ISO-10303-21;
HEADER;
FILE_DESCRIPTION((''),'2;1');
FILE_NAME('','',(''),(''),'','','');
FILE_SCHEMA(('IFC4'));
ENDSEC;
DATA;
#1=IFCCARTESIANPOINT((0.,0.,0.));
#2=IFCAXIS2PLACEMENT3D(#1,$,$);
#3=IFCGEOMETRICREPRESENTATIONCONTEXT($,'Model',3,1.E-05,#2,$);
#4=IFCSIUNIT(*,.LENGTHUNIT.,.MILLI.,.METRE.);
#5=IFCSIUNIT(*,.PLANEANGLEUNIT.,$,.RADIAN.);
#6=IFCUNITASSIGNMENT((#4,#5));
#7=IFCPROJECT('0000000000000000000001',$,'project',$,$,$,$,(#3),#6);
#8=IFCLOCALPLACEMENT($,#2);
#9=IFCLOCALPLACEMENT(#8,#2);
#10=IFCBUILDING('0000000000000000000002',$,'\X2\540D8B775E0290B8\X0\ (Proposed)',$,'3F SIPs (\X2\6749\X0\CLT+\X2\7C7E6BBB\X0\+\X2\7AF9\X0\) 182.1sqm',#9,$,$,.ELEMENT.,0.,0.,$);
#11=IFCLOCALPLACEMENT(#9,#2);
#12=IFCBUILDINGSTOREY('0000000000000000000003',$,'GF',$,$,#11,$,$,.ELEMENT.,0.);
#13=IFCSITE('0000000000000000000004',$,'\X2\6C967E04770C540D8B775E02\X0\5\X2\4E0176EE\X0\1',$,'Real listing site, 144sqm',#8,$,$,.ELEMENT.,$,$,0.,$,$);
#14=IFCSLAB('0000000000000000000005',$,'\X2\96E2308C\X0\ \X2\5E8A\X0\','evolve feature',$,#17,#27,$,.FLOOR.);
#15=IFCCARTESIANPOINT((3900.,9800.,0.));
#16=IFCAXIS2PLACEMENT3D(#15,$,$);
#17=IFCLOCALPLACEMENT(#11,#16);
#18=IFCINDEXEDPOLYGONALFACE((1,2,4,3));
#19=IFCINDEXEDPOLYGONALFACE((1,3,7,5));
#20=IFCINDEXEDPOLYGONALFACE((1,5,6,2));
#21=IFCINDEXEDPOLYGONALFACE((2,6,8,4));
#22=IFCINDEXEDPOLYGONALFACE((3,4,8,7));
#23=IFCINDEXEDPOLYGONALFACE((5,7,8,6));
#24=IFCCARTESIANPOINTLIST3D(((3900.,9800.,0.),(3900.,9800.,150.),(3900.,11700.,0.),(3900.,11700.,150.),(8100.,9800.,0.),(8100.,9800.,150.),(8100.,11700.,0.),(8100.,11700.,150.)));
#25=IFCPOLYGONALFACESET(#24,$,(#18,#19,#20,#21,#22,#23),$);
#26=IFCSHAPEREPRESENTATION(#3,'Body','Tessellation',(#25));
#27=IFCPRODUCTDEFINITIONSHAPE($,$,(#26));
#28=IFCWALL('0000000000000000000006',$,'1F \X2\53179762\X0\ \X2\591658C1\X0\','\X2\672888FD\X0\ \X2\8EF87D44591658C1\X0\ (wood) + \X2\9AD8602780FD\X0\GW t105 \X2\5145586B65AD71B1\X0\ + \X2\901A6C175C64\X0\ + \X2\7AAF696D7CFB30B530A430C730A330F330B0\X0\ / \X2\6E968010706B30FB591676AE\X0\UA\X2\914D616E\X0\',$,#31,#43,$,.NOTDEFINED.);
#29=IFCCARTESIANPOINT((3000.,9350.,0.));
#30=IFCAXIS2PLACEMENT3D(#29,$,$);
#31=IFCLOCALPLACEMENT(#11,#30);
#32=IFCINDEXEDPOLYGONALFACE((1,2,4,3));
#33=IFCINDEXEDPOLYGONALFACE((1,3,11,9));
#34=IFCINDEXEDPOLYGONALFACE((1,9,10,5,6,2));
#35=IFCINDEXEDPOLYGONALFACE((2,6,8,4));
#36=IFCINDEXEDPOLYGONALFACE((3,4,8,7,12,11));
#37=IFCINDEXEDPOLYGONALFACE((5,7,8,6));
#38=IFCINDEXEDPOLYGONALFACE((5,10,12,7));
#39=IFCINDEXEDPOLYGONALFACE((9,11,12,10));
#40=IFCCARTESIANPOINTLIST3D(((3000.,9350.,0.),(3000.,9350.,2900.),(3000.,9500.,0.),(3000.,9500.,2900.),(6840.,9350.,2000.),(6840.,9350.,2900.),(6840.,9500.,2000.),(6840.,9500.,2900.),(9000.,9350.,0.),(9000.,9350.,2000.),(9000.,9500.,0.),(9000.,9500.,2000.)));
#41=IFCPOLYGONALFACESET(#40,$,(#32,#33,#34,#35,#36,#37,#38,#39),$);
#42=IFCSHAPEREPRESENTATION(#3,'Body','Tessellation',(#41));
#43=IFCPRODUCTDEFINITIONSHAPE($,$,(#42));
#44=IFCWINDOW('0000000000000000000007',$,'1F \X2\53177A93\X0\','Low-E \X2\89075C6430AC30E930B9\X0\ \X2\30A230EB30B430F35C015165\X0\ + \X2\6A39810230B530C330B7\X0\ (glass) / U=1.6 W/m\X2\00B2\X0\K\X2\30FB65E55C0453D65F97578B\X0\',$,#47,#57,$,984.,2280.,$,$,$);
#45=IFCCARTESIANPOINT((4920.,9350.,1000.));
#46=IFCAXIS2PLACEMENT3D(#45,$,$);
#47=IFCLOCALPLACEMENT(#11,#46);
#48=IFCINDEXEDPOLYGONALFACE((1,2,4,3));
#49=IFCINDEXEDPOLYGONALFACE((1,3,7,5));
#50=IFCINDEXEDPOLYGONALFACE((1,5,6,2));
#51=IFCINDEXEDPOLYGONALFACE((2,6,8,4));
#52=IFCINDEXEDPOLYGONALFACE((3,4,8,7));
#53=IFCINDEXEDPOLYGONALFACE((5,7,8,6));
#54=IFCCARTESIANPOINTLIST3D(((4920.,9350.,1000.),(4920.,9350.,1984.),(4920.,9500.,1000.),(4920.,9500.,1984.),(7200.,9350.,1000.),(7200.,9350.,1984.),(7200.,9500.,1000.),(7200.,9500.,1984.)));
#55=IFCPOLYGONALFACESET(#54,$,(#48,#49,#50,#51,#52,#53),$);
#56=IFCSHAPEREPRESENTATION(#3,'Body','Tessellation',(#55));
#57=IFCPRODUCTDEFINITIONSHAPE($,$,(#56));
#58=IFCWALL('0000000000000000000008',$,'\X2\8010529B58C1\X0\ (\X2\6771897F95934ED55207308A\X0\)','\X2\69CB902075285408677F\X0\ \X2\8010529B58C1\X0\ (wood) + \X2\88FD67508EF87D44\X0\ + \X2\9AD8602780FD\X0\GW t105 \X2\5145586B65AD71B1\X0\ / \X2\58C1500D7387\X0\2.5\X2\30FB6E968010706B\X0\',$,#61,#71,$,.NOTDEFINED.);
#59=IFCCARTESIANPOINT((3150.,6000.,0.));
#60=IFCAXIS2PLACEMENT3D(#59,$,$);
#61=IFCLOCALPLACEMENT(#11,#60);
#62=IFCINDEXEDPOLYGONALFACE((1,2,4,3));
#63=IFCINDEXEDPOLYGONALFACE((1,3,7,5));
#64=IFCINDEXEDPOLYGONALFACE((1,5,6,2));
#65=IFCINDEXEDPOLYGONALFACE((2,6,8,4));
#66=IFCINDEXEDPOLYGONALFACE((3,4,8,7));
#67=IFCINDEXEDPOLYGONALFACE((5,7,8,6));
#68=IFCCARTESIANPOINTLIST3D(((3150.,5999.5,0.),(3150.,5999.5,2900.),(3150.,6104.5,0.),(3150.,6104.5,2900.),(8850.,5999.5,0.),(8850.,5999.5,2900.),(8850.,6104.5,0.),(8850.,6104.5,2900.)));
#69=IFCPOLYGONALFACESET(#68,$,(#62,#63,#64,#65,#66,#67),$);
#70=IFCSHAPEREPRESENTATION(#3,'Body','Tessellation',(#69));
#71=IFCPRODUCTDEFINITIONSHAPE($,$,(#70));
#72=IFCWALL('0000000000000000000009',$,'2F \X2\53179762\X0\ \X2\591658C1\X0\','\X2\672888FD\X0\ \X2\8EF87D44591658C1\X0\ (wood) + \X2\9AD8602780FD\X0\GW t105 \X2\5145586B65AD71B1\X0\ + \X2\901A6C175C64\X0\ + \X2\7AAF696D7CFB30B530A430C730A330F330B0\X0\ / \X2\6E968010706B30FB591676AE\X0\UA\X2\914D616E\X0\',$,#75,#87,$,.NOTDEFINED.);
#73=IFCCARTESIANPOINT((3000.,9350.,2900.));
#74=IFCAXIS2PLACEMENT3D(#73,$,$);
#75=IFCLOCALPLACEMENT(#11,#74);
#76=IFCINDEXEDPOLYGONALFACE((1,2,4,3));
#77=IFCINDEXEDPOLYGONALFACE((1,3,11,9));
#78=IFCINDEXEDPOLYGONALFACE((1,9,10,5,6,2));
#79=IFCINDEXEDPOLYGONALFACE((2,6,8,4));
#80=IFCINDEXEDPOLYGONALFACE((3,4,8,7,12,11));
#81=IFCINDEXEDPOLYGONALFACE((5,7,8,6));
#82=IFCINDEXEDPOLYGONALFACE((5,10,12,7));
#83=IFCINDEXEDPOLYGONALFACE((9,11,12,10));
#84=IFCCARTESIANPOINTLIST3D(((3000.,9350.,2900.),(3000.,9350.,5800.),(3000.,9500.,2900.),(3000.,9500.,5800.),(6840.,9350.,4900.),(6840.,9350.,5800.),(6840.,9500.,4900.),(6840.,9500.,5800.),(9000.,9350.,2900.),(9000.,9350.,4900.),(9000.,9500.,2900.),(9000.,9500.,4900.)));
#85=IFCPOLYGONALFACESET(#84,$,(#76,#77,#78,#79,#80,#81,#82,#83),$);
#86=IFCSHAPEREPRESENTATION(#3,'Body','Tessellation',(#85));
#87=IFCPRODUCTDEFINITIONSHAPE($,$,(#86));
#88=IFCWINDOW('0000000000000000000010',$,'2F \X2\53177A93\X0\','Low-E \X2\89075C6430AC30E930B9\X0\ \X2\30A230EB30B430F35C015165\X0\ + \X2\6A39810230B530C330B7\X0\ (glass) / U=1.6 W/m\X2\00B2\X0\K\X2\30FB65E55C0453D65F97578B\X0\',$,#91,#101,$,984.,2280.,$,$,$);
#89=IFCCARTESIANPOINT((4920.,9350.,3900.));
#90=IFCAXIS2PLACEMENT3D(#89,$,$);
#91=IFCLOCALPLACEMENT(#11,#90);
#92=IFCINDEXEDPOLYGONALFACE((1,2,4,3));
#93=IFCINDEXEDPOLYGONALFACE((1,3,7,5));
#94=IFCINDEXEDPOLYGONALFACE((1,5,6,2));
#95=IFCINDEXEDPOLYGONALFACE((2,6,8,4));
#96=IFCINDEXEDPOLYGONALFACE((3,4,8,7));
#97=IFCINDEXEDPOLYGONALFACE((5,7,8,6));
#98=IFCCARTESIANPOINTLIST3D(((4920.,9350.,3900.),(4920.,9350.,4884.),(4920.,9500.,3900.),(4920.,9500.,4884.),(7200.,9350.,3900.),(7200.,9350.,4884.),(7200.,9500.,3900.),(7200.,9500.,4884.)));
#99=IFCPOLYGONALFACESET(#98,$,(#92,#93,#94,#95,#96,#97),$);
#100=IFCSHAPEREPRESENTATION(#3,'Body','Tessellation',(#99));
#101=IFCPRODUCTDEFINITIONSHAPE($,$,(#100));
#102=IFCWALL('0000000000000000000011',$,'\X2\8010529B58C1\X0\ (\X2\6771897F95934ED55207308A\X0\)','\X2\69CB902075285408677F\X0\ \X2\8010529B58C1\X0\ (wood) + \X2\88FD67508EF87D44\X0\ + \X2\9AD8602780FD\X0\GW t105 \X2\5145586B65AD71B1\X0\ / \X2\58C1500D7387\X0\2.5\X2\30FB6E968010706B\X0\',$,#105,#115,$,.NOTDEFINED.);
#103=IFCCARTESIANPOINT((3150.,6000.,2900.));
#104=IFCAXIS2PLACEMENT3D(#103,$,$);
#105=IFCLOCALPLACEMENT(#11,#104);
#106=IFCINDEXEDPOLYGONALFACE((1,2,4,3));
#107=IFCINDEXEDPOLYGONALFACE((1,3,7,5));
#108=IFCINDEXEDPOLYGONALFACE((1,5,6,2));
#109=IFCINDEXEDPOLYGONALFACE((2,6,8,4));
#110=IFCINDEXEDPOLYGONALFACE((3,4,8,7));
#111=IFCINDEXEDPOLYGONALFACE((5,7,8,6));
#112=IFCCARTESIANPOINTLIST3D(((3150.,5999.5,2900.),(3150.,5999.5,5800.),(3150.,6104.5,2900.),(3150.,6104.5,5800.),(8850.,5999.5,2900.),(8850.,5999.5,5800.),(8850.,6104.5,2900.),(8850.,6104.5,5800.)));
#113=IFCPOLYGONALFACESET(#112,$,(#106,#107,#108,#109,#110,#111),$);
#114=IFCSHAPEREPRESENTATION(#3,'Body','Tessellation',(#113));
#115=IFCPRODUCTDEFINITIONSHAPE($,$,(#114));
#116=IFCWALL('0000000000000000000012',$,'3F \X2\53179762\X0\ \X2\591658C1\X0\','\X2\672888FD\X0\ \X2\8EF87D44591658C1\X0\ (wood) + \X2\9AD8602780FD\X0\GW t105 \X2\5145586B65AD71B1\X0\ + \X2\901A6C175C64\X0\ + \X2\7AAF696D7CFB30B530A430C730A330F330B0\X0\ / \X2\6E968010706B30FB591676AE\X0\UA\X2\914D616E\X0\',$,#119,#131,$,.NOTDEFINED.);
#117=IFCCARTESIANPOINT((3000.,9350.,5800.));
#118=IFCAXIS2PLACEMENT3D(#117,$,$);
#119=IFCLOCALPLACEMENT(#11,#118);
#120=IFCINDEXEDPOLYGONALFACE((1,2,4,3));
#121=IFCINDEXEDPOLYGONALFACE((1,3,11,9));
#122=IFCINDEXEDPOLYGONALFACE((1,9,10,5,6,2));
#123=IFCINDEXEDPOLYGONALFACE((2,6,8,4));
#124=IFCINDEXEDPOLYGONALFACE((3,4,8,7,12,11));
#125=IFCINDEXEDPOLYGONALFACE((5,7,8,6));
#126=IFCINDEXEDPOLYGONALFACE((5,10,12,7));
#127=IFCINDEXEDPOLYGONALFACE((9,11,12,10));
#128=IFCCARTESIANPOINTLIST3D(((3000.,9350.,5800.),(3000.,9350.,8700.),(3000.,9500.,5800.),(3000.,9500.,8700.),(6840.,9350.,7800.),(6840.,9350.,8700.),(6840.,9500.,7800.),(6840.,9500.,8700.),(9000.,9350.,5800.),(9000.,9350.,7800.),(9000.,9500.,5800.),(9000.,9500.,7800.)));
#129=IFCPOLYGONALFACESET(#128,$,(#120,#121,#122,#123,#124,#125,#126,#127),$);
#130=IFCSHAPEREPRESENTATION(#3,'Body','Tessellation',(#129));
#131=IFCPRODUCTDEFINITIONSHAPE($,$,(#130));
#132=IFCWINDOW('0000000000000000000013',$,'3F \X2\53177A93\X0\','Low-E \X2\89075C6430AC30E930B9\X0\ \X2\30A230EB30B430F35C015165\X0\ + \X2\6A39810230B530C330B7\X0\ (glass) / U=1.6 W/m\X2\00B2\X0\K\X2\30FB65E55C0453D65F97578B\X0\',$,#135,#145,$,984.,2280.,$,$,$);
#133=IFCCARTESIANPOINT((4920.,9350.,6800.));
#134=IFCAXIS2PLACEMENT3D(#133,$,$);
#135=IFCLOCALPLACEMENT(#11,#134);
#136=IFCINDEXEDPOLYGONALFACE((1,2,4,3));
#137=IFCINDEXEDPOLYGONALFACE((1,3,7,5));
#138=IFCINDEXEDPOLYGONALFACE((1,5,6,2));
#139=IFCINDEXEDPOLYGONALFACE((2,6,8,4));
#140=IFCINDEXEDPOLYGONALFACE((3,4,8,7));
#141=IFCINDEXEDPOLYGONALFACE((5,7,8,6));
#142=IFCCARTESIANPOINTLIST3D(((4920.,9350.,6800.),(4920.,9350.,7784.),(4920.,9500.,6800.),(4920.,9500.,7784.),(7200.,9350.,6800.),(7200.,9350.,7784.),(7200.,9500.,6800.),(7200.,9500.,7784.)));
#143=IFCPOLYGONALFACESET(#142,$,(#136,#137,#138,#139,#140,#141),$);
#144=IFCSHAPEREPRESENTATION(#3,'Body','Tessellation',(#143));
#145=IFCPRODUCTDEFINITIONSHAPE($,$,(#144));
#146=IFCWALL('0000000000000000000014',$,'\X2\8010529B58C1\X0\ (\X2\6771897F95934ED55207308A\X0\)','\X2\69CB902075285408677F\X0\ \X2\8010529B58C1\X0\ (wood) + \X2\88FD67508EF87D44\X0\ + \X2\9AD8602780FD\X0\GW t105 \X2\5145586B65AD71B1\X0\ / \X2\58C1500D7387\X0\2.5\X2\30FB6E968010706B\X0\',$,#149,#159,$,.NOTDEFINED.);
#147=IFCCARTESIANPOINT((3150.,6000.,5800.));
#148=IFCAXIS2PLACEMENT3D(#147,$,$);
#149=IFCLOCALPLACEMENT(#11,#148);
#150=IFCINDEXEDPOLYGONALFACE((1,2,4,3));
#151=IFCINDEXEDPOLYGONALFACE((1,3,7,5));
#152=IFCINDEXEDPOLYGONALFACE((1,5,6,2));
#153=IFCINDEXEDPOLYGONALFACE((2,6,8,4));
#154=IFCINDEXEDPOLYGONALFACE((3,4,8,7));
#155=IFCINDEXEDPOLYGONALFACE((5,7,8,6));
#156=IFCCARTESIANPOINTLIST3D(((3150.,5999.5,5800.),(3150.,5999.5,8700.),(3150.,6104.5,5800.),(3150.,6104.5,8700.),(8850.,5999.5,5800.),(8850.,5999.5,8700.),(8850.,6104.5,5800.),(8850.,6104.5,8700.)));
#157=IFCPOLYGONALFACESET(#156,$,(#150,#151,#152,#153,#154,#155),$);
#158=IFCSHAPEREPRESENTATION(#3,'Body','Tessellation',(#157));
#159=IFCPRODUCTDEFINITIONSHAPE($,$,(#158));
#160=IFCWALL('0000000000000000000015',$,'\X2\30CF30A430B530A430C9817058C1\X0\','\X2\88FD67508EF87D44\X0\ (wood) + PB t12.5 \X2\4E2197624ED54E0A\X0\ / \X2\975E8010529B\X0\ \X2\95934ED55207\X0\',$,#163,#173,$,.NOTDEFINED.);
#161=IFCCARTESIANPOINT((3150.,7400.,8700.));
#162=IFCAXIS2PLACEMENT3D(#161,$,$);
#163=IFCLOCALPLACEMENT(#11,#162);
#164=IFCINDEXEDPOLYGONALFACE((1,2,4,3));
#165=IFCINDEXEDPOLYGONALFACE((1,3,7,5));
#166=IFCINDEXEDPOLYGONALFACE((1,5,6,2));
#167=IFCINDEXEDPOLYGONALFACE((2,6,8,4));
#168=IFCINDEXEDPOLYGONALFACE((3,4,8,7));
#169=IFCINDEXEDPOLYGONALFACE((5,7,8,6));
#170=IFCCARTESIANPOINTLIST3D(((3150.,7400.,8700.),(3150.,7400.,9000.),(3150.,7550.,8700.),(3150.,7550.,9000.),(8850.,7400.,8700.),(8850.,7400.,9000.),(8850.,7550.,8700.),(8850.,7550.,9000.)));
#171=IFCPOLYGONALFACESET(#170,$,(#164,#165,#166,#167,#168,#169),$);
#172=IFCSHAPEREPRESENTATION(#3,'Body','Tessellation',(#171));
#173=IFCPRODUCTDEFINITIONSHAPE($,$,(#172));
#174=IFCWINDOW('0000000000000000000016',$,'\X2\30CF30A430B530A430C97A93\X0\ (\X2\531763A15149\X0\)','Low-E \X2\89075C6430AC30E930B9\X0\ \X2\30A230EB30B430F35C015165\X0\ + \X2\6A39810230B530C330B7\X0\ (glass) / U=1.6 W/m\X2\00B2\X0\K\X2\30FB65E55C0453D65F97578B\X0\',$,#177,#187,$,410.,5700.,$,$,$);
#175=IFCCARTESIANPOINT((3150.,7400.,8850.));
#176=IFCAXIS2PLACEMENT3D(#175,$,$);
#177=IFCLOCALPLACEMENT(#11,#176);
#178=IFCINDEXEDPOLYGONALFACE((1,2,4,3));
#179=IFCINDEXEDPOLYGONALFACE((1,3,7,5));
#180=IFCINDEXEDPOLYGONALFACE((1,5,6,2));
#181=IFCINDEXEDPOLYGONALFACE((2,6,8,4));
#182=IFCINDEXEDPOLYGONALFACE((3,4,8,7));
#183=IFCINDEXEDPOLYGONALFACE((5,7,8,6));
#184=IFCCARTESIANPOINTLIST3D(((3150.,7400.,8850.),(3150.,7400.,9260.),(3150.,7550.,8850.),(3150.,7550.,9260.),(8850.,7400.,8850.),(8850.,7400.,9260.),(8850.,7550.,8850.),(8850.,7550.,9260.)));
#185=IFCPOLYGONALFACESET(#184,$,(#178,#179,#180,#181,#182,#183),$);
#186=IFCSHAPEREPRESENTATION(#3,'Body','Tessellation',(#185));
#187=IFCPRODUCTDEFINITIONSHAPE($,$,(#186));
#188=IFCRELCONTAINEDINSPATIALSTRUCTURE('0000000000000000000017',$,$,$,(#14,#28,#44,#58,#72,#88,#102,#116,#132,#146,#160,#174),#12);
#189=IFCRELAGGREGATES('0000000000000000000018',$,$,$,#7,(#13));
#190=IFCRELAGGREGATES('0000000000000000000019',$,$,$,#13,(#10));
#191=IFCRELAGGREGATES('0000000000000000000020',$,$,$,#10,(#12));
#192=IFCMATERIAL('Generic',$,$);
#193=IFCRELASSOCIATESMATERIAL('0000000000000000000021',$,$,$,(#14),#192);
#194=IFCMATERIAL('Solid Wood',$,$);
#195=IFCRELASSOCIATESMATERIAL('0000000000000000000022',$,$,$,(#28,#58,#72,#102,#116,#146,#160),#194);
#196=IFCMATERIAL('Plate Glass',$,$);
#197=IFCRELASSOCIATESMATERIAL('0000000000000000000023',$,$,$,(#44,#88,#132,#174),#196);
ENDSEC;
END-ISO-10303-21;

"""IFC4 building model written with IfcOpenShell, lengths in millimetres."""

from ifc_helpers import new_model, si_unit, frame, frame_2d, origin, place, context, project, spatial, rectangle, extrude, material, element, fill, save


model = new_model("IFC4")

# Units and contexts
model_context = context("Model", 3, precision=1e-05, world=origin())
ifc_project = project(units=[si_unit("LENGTHUNIT", "METRE", prefix="MILLI"), si_unit("PLANEANGLEUNIT", "RADIAN")], contexts=[model_context])

# Site, building, storey
site_placement = place(None, origin())
site = spatial("IfcSite", under=ifc_project, at=site_placement, Name="沖縄県名護市5丁目1", ObjectType="Real listing site, 144sqm", CompositionType="ELEMENT", RefElevation=0.0)
building_placement = place(site_placement, origin())
building = spatial("IfcBuilding", under=site, at=building_placement, Name="名護市邸 (Proposed)", ObjectType="3F SIPs (杉CLT+籾殻+竹) 182.1sqm", CompositionType="ELEMENT", ElevationOfRefHeight=0.0, ElevationOfTerrain=0.0)
storey_placement = place(building_placement, origin())
storey = spatial("IfcBuildingStorey", under=building, at=storey_placement, Name="GF", CompositionType="ELEMENT", Elevation=0.0)

# Slab
ifc_material_1 = material(Name="Generic")
slab_placement = place(storey_placement, frame((3900.0, 9800.0, 0.0)))
element("IfcSlab", 1, at=slab_placement, inside=storey, material=ifc_material_1, Name="離れ 床", Description="evolve feature", PredefinedType="FLOOR", context=model_context, shape_type="SweptSolid", body=[
    extrude(rectangle(XDim=4200.0, YDim=1900.0, at=frame_2d((2100.0, 950.0))), frame((3900.0, 9800.0, 0.0)), (0.0, 0.0, 1.0), 150.0),
])

# Wall, opening, window
ifc_material_2 = material(Name="Solid Wood")
wall_1_placement = place(storey_placement, frame((3000.0, 9350.0, 0.0)))
wall_1 = element("IfcWall", 2, at=wall_1_placement, inside=storey, material=ifc_material_2, Name="1F 北面 外壁", Description="木製 軸組外壁 (wood) + 高性能GW t105 充填断熱 + 通気層 + 窯業系サイディング / 準耐火・外皮UA配慮", PredefinedType="NOTDEFINED", context=model_context, shape_type="SweptSolid", body=[
    extrude(rectangle(XDim=6000.0, YDim=150.0, at=frame_2d((3000.0, 75.0))), frame((3000.0, 9350.0, 0.0)), (0.0, 0.0, 1.0), 2900.0),
])
opening_1_placement = place(storey_placement, frame((4920.0, 9350.0, 1000.0)))
opening_1 = element("IfcOpeningElement", 3, at=opening_1_placement, cuts=wall_1, PredefinedType="NOTDEFINED", context=model_context, shape_type="SweptSolid", body=[
    extrude(rectangle(XDim=2280.0, YDim=150.0, at=frame_2d((1140.0, 75.0))), frame((4920.0, 9350.0, 1000.0)), (0.0, 0.0, 1.0), 984.0),
])
ifc_material_3 = material(Name="Plate Glass")
window_1_placement = place(storey_placement, frame((4920.0, 9350.0, 1000.0)))
window_1 = element("IfcWindow", 4, at=window_1_placement, inside=storey, material=ifc_material_3, Name="1F 北窓", Description="Low-E 複層ガラス アルゴン封入 + 樹脂サッシ (glass) / U=1.6 W/m²K・日射取得型", OverallHeight=984.0, OverallWidth=2280.0, context=model_context, shape_type="SweptSolid", body=[
    extrude(rectangle(XDim=2280.0, YDim=150.0, at=frame_2d((1140.0, 75.0))), frame((4920.0, 9350.0, 1000.0)), (0.0, 0.0, 1.0), 984.0),
])
fill(opening_1, window_1)

# Wall
wall_2_placement = place(storey_placement, frame((3150.0, 6000.0, 0.0)))
element("IfcWall", 5, at=wall_2_placement, inside=storey, material=ifc_material_2, Name="耐力壁 (東西間仕切り)", Description="構造用合板 耐力壁 (wood) + 製材軸組 + 高性能GW t105 充填断熱 / 壁倍率2.5・準耐火", PredefinedType="NOTDEFINED", context=model_context, shape_type="SweptSolid", body=[
    extrude(rectangle(XDim=5700.0, YDim=105.0, at=frame_2d((2850.0, 52.0))), frame((3150.0, 6000.0, 0.0)), (0.0, 0.0, 1.0), 2900.0),
])

# Wall, opening, window
wall_3_placement = place(storey_placement, frame((3000.0, 9350.0, 2900.0)))
wall_3 = element("IfcWall", 6, at=wall_3_placement, inside=storey, material=ifc_material_2, Name="2F 北面 外壁", Description="木製 軸組外壁 (wood) + 高性能GW t105 充填断熱 + 通気層 + 窯業系サイディング / 準耐火・外皮UA配慮", PredefinedType="NOTDEFINED", context=model_context, shape_type="SweptSolid", body=[
    extrude(rectangle(XDim=6000.0, YDim=150.0, at=frame_2d((3000.0, 75.0))), frame((3000.0, 9350.0, 2900.0)), (0.0, 0.0, 1.0), 2900.0),
])
opening_2_placement = place(storey_placement, frame((4920.0, 9350.0, 3900.0)))
opening_2 = element("IfcOpeningElement", 7, at=opening_2_placement, cuts=wall_3, PredefinedType="NOTDEFINED", context=model_context, shape_type="SweptSolid", body=[
    extrude(rectangle(XDim=2280.0, YDim=150.0, at=frame_2d((1140.0, 75.0))), frame((4920.0, 9350.0, 3900.0)), (0.0, 0.0, 1.0), 984.0),
])
window_2_placement = place(storey_placement, frame((4920.0, 9350.0, 3900.0)))
window_2 = element("IfcWindow", 8, at=window_2_placement, inside=storey, material=ifc_material_3, Name="2F 北窓", Description="Low-E 複層ガラス アルゴン封入 + 樹脂サッシ (glass) / U=1.6 W/m²K・日射取得型", OverallHeight=984.0, OverallWidth=2280.0, context=model_context, shape_type="SweptSolid", body=[
    extrude(rectangle(XDim=2280.0, YDim=150.0, at=frame_2d((1140.0, 75.0))), frame((4920.0, 9350.0, 3900.0)), (0.0, 0.0, 1.0), 984.0),
])
fill(opening_2, window_2)

# Wall
wall_4_placement = place(storey_placement, frame((3150.0, 6000.0, 2900.0)))
element("IfcWall", 9, at=wall_4_placement, inside=storey, material=ifc_material_2, Name="耐力壁 (東西間仕切り)", Description="構造用合板 耐力壁 (wood) + 製材軸組 + 高性能GW t105 充填断熱 / 壁倍率2.5・準耐火", PredefinedType="NOTDEFINED", context=model_context, shape_type="SweptSolid", body=[
    extrude(rectangle(XDim=5700.0, YDim=105.0, at=frame_2d((2850.0, 52.0))), frame((3150.0, 6000.0, 2900.0)), (0.0, 0.0, 1.0), 2900.0),
])

# Wall, opening, window
wall_5_placement = place(storey_placement, frame((3000.0, 9350.0, 5800.0)))
wall_5 = element("IfcWall", 10, at=wall_5_placement, inside=storey, material=ifc_material_2, Name="3F 北面 外壁", Description="木製 軸組外壁 (wood) + 高性能GW t105 充填断熱 + 通気層 + 窯業系サイディング / 準耐火・外皮UA配慮", PredefinedType="NOTDEFINED", context=model_context, shape_type="SweptSolid", body=[
    extrude(rectangle(XDim=6000.0, YDim=150.0, at=frame_2d((3000.0, 75.0))), frame((3000.0, 9350.0, 5800.0)), (0.0, 0.0, 1.0), 2900.0),
])
opening_3_placement = place(storey_placement, frame((4920.0, 9350.0, 6800.0)))
opening_3 = element("IfcOpeningElement", 11, at=opening_3_placement, cuts=wall_5, PredefinedType="NOTDEFINED", context=model_context, shape_type="SweptSolid", body=[
    extrude(rectangle(XDim=2280.0, YDim=150.0, at=frame_2d((1140.0, 75.0))), frame((4920.0, 9350.0, 6800.0)), (0.0, 0.0, 1.0), 984.0),
])
window_3_placement = place(storey_placement, frame((4920.0, 9350.0, 6800.0)))
window_3 = element("IfcWindow", 12, at=window_3_placement, inside=storey, material=ifc_material_3, Name="3F 北窓", Description="Low-E 複層ガラス アルゴン封入 + 樹脂サッシ (glass) / U=1.6 W/m²K・日射取得型", OverallHeight=984.0, OverallWidth=2280.0, context=model_context, shape_type="SweptSolid", body=[
    extrude(rectangle(XDim=2280.0, YDim=150.0, at=frame_2d((1140.0, 75.0))), frame((4920.0, 9350.0, 6800.0)), (0.0, 0.0, 1.0), 984.0),
])
fill(opening_3, window_3)

# Wall
wall_6_placement = place(storey_placement, frame((3150.0, 6000.0, 5800.0)))
element("IfcWall", 13, at=wall_6_placement, inside=storey, material=ifc_material_2, Name="耐力壁 (東西間仕切り)", Description="構造用合板 耐力壁 (wood) + 製材軸組 + 高性能GW t105 充填断熱 / 壁倍率2.5・準耐火", PredefinedType="NOTDEFINED", context=model_context, shape_type="SweptSolid", body=[
    extrude(rectangle(XDim=5700.0, YDim=105.0, at=frame_2d((2850.0, 52.0))), frame((3150.0, 6000.0, 5800.0)), (0.0, 0.0, 1.0), 2900.0),
])

# Wall, opening, window
wall_7_placement = place(storey_placement, frame((3150.0, 7400.0, 8700.0)))
wall_7 = element("IfcWall", 14, at=wall_7_placement, inside=storey, material=ifc_material_2, Name="ハイサイド腰壁", Description="製材軸組 (wood) + PB t12.5 両面仕上 / 非耐力 間仕切", PredefinedType="NOTDEFINED", context=model_context, shape_type="SweptSolid", body=[
    extrude(rectangle(XDim=5700.0, YDim=150.0, at=frame_2d((2850.0, 75.0))), frame((3150.0, 7400.0, 8700.0)), (0.0, 0.0, 1.0), 700.0),
])
opening_4_placement = place(storey_placement, frame((3150.0, 7400.0, 8850.0)))
opening_4 = element("IfcOpeningElement", 15, at=opening_4_placement, cuts=wall_7, PredefinedType="NOTDEFINED", context=model_context, shape_type="SweptSolid", body=[
    extrude(rectangle(XDim=5700.0, YDim=150.0, at=frame_2d((2850.0, 75.0))), frame((3150.0, 7400.0, 8850.0)), (0.0, 0.0, 1.0), 410.0),
])
window_4_placement = place(storey_placement, frame((3150.0, 7400.0, 8850.0)))
window_4 = element("IfcWindow", 16, at=window_4_placement, inside=storey, material=ifc_material_3, Name="ハイサイド窓 (北採光)", Description="Low-E 複層ガラス アルゴン封入 + 樹脂サッシ (glass) / U=1.6 W/m²K・日射取得型", OverallHeight=410.0, OverallWidth=5700.0, context=model_context, shape_type="SweptSolid", body=[
    extrude(rectangle(XDim=5700.0, YDim=150.0, at=frame_2d((2850.0, 75.0))), frame((3150.0, 7400.0, 8850.0)), (0.0, 0.0, 1.0), 410.0),
])
fill(opening_4, window_4)

save(model, "model.ifc")
